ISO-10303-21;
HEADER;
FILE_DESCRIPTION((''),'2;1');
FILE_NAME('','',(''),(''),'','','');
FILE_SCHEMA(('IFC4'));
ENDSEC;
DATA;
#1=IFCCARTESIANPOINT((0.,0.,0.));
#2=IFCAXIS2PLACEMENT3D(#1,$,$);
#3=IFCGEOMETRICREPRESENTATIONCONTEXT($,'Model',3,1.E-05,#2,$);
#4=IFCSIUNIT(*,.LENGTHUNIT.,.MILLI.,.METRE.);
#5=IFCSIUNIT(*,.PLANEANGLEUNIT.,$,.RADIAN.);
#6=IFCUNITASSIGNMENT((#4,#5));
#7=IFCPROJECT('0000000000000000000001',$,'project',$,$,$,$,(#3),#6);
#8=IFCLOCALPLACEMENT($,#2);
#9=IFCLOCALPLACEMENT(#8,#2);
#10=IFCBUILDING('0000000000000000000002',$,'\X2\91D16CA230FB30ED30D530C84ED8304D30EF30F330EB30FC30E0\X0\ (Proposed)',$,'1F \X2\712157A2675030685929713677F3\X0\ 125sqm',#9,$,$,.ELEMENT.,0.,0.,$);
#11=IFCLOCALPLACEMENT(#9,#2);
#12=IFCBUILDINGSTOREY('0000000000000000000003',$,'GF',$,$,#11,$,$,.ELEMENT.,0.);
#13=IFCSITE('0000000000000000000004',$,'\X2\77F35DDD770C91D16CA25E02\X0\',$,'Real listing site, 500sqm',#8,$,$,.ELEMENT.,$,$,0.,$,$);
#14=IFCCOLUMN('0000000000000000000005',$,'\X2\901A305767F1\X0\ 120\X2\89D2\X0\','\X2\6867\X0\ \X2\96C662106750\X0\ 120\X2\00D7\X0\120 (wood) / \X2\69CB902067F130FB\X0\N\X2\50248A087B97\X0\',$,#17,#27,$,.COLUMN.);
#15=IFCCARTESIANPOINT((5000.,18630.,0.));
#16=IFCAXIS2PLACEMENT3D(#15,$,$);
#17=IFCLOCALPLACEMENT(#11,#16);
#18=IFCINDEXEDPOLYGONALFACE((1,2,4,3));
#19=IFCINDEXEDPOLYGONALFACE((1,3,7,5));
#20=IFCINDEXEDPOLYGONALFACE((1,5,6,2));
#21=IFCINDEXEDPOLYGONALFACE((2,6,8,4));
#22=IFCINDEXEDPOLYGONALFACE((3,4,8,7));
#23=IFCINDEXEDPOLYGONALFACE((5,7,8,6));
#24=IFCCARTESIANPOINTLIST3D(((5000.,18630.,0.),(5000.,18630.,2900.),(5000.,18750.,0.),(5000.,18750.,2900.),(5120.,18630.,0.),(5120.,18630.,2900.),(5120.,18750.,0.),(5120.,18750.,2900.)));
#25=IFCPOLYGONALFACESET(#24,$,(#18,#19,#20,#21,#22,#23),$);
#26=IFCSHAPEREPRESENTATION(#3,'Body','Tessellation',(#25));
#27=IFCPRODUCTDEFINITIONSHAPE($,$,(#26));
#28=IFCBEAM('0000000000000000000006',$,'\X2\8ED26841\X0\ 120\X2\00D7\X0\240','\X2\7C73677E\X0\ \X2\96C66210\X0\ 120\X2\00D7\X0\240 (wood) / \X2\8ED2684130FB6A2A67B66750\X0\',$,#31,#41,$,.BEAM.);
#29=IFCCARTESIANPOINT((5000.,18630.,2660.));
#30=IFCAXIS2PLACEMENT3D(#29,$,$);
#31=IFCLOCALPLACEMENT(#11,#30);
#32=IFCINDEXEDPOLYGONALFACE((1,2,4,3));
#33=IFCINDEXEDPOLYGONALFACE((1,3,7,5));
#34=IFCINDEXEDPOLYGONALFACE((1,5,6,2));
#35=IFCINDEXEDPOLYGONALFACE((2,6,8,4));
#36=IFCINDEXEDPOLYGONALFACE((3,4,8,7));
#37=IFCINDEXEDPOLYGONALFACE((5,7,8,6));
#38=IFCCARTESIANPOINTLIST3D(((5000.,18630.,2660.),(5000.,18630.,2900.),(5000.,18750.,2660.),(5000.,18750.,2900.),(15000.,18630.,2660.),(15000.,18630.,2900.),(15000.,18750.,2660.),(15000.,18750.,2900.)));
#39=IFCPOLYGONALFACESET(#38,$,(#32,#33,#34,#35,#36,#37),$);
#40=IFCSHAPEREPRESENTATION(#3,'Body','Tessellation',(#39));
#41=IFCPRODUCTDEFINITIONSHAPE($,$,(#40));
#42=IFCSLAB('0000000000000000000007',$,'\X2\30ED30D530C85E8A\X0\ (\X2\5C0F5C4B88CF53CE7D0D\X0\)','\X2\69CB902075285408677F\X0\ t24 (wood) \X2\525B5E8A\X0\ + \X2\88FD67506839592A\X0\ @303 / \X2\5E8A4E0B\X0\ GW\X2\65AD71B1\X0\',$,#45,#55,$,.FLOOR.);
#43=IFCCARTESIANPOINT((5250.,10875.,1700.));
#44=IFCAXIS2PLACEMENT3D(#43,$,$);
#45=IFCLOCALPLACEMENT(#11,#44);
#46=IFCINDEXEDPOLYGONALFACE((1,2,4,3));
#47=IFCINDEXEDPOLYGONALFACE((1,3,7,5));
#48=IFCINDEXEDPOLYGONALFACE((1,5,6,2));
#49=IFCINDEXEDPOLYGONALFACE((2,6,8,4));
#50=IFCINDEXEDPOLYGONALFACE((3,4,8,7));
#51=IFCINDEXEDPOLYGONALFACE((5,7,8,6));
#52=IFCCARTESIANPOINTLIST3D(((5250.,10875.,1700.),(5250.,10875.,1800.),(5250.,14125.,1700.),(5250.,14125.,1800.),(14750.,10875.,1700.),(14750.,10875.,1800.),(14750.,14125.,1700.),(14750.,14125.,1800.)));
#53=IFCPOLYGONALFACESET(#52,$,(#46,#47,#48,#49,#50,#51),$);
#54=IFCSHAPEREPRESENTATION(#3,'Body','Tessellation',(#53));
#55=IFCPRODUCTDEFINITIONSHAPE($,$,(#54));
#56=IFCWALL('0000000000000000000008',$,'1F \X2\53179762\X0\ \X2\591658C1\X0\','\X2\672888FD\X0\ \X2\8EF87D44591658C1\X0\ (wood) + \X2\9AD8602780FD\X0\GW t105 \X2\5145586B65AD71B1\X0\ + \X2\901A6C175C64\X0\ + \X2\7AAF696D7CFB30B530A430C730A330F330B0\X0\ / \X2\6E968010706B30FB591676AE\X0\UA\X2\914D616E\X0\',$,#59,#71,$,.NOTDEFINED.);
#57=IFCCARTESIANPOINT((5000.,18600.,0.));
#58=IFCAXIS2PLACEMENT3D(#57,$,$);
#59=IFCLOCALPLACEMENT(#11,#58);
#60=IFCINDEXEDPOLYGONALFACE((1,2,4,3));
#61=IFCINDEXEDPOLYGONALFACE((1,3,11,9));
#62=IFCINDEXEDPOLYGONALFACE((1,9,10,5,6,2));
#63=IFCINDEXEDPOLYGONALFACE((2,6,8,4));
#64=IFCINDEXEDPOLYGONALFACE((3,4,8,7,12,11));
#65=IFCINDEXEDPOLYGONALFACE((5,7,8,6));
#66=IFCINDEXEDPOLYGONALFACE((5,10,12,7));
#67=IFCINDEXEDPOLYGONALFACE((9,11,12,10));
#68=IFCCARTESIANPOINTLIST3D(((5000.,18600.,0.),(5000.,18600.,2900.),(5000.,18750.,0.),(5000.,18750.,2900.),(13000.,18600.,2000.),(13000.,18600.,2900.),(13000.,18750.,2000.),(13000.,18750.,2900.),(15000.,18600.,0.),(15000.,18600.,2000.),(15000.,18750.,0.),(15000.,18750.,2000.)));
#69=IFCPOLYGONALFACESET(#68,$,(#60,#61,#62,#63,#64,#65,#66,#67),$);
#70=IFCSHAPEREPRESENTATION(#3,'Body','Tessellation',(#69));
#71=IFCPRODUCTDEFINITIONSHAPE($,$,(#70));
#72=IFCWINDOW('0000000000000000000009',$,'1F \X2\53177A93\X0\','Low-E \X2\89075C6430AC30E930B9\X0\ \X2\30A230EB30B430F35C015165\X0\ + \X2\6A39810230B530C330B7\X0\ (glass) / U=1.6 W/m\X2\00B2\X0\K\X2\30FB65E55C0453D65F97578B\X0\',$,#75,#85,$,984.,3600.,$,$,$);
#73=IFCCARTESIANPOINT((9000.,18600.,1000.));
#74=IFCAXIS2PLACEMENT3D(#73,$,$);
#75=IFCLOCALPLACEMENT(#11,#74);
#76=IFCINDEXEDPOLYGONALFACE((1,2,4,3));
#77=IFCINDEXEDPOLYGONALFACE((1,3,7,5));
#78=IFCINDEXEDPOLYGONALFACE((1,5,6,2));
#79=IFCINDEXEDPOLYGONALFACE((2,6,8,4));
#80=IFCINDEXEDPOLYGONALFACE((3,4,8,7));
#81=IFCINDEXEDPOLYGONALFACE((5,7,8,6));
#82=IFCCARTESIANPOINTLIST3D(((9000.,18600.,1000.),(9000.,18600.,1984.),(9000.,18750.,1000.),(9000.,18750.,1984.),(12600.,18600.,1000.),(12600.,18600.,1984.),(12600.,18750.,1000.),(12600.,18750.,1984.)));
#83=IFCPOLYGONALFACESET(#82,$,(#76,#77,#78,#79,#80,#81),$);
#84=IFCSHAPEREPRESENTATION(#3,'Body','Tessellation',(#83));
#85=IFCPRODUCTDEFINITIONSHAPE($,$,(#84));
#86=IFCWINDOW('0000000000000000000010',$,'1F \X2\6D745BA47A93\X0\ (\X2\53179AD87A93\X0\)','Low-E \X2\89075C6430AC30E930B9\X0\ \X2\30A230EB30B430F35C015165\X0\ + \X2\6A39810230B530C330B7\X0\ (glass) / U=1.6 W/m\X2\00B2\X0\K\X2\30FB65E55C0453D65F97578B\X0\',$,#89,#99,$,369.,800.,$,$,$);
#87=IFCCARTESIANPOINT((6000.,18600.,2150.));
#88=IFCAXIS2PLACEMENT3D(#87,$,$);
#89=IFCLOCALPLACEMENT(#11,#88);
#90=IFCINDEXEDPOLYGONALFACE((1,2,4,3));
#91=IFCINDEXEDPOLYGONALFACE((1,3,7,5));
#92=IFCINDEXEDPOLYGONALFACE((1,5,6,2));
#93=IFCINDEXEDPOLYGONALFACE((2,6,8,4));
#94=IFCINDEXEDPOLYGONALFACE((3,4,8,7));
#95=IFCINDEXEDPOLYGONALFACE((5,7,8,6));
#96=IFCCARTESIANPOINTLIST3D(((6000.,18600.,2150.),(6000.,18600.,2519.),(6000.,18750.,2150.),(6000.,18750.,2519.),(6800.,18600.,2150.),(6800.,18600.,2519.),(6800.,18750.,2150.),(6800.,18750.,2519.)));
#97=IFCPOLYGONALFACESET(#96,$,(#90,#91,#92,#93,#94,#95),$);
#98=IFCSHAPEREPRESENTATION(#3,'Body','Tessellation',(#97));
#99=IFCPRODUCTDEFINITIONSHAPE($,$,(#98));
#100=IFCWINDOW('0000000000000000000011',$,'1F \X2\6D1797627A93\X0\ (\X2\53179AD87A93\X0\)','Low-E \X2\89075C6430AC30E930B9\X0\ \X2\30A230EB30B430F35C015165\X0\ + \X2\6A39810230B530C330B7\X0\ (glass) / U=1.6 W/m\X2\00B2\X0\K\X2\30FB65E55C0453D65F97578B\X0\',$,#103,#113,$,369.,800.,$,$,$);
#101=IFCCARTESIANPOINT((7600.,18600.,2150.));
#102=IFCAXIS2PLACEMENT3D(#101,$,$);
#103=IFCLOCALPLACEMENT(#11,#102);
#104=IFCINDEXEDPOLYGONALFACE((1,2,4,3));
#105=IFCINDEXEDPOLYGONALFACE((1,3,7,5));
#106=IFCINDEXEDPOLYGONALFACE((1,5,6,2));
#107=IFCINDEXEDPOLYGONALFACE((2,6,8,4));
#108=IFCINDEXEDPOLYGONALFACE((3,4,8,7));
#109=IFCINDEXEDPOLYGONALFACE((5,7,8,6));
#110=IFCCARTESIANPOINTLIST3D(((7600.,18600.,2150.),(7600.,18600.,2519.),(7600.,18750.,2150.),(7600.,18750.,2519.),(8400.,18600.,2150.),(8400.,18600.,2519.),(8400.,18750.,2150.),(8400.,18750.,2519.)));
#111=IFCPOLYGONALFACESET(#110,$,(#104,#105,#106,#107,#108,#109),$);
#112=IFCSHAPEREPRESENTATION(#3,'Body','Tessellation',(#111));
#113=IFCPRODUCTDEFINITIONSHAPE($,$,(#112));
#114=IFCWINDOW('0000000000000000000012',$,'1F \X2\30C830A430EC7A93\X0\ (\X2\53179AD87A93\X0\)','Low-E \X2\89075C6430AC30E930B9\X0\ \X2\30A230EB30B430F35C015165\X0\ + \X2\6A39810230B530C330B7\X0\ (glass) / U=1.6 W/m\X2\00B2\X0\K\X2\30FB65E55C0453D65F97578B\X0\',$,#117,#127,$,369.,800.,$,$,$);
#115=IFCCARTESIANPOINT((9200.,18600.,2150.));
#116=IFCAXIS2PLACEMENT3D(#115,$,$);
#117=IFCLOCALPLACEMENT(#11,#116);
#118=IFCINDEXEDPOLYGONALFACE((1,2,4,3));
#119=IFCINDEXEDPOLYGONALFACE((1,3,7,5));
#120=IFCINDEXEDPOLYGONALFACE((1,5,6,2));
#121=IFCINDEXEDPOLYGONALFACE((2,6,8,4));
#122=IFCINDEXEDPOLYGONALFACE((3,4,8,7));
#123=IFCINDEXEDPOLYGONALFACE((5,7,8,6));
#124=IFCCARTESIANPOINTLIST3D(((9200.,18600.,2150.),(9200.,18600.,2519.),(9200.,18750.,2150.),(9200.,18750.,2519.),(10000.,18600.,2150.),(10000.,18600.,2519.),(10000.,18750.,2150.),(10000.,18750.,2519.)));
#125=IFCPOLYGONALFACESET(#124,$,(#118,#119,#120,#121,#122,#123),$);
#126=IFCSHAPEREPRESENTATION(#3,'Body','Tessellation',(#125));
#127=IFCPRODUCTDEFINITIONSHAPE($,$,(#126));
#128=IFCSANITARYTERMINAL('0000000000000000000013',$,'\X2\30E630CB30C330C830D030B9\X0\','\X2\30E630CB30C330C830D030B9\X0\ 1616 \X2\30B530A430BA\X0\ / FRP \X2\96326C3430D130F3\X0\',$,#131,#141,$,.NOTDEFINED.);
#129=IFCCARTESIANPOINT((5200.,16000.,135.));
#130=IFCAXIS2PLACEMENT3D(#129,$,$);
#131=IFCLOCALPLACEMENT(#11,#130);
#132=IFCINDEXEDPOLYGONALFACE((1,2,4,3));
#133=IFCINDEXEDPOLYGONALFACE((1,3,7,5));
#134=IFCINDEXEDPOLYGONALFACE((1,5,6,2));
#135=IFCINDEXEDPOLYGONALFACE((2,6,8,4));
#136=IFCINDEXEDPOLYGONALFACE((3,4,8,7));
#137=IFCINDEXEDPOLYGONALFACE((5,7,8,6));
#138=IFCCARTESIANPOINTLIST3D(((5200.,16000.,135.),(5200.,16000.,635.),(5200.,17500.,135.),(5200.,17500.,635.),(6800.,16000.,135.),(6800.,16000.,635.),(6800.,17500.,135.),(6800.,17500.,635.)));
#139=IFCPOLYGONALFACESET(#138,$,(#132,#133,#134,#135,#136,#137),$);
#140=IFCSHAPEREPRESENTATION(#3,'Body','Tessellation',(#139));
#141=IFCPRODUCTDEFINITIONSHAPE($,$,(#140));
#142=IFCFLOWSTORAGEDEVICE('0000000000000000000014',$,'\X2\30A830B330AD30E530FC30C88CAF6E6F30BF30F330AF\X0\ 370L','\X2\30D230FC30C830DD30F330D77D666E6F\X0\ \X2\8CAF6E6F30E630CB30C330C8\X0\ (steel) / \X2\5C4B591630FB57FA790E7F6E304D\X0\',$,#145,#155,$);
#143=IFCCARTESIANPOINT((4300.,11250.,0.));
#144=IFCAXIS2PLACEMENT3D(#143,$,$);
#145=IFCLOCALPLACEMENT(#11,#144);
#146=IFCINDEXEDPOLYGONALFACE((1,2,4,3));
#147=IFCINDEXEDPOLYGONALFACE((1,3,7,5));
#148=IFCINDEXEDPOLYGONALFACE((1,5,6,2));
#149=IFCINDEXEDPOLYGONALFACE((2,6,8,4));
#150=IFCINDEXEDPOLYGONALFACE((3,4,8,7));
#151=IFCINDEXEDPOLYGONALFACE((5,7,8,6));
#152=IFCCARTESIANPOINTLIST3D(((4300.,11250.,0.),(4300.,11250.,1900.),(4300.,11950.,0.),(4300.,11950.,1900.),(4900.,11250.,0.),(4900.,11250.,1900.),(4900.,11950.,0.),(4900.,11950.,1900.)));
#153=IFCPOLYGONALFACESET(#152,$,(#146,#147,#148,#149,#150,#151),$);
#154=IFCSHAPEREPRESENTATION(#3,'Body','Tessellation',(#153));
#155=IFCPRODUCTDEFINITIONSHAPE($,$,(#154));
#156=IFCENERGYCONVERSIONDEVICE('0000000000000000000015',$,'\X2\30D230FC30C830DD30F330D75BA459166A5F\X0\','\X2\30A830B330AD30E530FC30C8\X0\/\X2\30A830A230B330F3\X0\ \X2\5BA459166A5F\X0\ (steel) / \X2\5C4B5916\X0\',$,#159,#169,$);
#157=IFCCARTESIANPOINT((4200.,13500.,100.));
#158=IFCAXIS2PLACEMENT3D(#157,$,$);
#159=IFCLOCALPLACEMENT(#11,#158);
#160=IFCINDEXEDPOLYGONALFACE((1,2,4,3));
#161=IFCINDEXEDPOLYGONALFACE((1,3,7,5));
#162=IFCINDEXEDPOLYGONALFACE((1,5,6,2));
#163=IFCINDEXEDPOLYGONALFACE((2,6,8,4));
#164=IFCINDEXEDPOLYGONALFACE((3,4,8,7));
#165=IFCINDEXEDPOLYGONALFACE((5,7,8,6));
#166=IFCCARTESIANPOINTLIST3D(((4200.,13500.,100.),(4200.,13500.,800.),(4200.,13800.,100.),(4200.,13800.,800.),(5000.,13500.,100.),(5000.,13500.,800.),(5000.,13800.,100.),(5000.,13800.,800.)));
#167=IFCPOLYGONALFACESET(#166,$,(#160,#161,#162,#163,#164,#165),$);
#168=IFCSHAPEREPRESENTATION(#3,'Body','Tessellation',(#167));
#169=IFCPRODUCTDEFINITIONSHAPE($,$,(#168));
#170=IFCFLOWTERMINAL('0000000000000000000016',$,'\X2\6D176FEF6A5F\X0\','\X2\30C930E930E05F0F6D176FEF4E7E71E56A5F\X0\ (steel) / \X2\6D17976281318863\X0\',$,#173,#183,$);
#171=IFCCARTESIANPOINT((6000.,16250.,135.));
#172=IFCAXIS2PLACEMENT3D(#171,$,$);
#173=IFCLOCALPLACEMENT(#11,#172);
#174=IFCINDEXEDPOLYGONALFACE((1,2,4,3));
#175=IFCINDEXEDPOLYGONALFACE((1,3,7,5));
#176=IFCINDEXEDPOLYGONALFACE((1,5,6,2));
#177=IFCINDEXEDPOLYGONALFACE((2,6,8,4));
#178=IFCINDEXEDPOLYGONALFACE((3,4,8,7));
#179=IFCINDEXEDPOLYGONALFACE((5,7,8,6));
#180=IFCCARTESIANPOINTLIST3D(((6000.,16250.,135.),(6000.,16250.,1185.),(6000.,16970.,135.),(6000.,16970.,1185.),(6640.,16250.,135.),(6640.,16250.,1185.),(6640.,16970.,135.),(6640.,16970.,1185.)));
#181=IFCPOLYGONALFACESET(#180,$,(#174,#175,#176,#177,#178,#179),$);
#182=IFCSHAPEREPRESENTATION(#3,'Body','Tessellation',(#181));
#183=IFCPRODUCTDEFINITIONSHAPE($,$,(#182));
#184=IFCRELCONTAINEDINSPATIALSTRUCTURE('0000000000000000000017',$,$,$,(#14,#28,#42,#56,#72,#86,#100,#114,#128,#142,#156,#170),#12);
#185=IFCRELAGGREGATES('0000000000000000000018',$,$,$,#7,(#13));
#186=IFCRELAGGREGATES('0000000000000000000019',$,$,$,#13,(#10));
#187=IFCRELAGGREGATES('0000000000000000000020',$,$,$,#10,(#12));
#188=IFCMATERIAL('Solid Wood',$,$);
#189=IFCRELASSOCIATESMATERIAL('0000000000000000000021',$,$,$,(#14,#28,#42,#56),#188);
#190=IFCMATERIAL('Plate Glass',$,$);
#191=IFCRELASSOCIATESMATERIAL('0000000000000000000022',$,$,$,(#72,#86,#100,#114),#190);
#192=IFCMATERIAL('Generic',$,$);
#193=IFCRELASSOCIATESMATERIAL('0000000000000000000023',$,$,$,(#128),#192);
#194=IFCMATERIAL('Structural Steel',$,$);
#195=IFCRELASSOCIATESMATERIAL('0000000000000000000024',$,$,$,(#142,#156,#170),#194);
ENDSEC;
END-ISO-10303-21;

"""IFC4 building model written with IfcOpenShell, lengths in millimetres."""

from ifc_helpers import new_model, si_unit, frame, frame_2d, origin, place, context, project, spatial, rectangle, extrude, material, element, fill, save


model = new_model("IFC4")

# Units and contexts
model_context = context("Model", 3, precision=1e-05, world=origin())
ifc_project = project(units=[si_unit("LENGTHUNIT", "METRE", prefix="MILLI"), si_unit("PLANEANGLEUNIT", "RADIAN")], contexts=[model_context])

# Site, building, storey
site_placement = place(None, origin())
site = spatial("IfcSite", under=ifc_project, at=site_placement, Name="石川県金沢市", ObjectType="Real listing site, 500sqm", CompositionType="ELEMENT", RefElevation=0.0)
building_placement = place(site_placement, origin())
building = spatial("IfcBuilding", under=site, at=building_placement, Name="金沢・ロフト付きワンルーム (Proposed)", ObjectType="1F 無垢材と天然石 125sqm", CompositionType="ELEMENT", ElevationOfRefHeight=0.0, ElevationOfTerrain=0.0)
storey_placement = place(building_placement, origin())
storey = spatial("IfcBuildingStorey", under=building, at=storey_placement, Name="GF", CompositionType="ELEMENT", Elevation=0.0)

# Column
ifc_material_1 = material(Name="Solid Wood")
column_1_placement = place(storey_placement, frame((5000.0, 18630.0, 0.0)))
element("IfcColumn", 1, at=column_1_placement, inside=storey, material=ifc_material_1, Name="通し柱 120角", Description="桧 集成材 120×120 (wood) / 構造柱・N値計算", PredefinedType="COLUMN", context=model_context, shape_type="SweptSolid", body=[
    extrude(rectangle(XDim=120.0, YDim=120.0, at=frame_2d((60.0, 60.0))), frame((5000.0, 18630.0, 0.0)), (0.0, 0.0, 1.0), 2900.0),
])

# Beam
beam_1_placement = place(storey_placement, frame((5000.0, 18630.0, 2660.0)))
element("IfcBeam", 2, at=beam_1_placement, inside=storey, material=ifc_material_1, Name="軒桁 120×240", Description="米松 集成 120×240 (wood) / 軒桁・横架材", PredefinedType="BEAM", context=model_context, shape_type="SweptSolid", body=[
    extrude(rectangle(XDim=10000.0, YDim=120.0, at=frame_2d((5000.0, 60.0))), frame((5000.0, 18630.0, 2660.0)), (0.0, 0.0, 1.0), 240.0),
])

# Slab
slab_placement = place(storey_placement, frame((5250.0, 10875.0, 1700.0)))
element("IfcSlab", 3, at=slab_placement, inside=storey, material=ifc_material_1, Name="ロフト床 (小屋裏収納)", Description="構造用合板 t24 (wood) 剛床 + 製材根太 @303 / 床下 GW断熱", PredefinedType="FLOOR", context=model_context, shape_type="SweptSolid", body=[
    extrude(rectangle(XDim=9500.0, YDim=3250.0, at=frame_2d((4750.0, 1625.0))), frame((5250.0, 10875.0, 1700.0)), (0.0, 0.0, 1.0), 100.0),
])

# Wall, openings, windows
wall_1_placement = place(storey_placement, frame((5000.0, 18600.0, 0.0)))
wall_1 = element("IfcWall", 4, at=wall_1_placement, inside=storey, material=ifc_material_1, Name="1F 北面 外壁", Description="木製 軸組外壁 (wood) + 高性能GW t105 充填断熱 + 通気層 + 窯業系サイディング / 準耐火・外皮UA配慮", PredefinedType="NOTDEFINED", context=model_context, shape_type="SweptSolid", body=[
    extrude(rectangle(XDim=10000.0, YDim=150.0, at=frame_2d((5000.0, 75.0))), frame((5000.0, 18600.0, 0.0)), (0.0, 0.0, 1.0), 2900.0),
])
opening_1_placement = place(storey_placement, frame((9000.0, 18600.0, 1000.0)))
opening_1 = element("IfcOpeningElement", 5, at=opening_1_placement, cuts=wall_1, PredefinedType="NOTDEFINED", context=model_context, shape_type="SweptSolid", body=[
    extrude(rectangle(XDim=3600.0, YDim=150.0, at=frame_2d((1800.0, 75.0))), frame((9000.0, 18600.0, 1000.0)), (0.0, 0.0, 1.0), 984.0),
])
opening_2_placement = place(storey_placement, frame((6000.0, 18600.0, 2150.0)))
opening_2 = element("IfcOpeningElement", 6, at=opening_2_placement, cuts=wall_1, PredefinedType="NOTDEFINED", context=model_context, shape_type="SweptSolid", body=[
    extrude(rectangle(XDim=800.0, YDim=150.0, at=frame_2d((400.0, 75.0))), frame((6000.0, 18600.0, 2150.0)), (0.0, 0.0, 1.0), 369.0),
])
opening_3_placement = place(storey_placement, frame((7600.0, 18600.0, 2150.0)))
opening_3 = element("IfcOpeningElement", 7, at=opening_3_placement, cuts=wall_1, PredefinedType="NOTDEFINED", context=model_context, shape_type="SweptSolid", body=[
    extrude(rectangle(XDim=800.0, YDim=150.0, at=frame_2d((400.0, 75.0))), frame((7600.0, 18600.0, 2150.0)), (0.0, 0.0, 1.0), 369.0),
])
opening_4_placement = place(storey_placement, frame((9200.0, 18600.0, 2150.0)))
opening_4 = element("IfcOpeningElement", 8, at=opening_4_placement, cuts=wall_1, PredefinedType="NOTDEFINED", context=model_context, shape_type="SweptSolid", body=[
    extrude(rectangle(XDim=800.0, YDim=150.0, at=frame_2d((400.0, 75.0))), frame((9200.0, 18600.0, 2150.0)), (0.0, 0.0, 1.0), 369.0),
])
ifc_material_2 = material(Name="Plate Glass")
window_1_placement = place(storey_placement, frame((9000.0, 18600.0, 1000.0)))
window_1 = element("IfcWindow", 9, at=window_1_placement, inside=storey, material=ifc_material_2, Name="1F 北窓", Description="Low-E 複層ガラス アルゴン封入 + 樹脂サッシ (glass) / U=1.6 W/m²K・日射取得型", OverallHeight=984.0, OverallWidth=3600.0, context=model_context, shape_type="SweptSolid", body=[
    extrude(rectangle(XDim=3600.0, YDim=150.0, at=frame_2d((1800.0, 75.0))), frame((9000.0, 18600.0, 1000.0)), (0.0, 0.0, 1.0), 984.0),
])
fill(opening_1, window_1)
window_2_placement = place(storey_placement, frame((6000.0, 18600.0, 2150.0)))
window_2 = element("IfcWindow", 10, at=window_2_placement, inside=storey, material=ifc_material_2, Name="1F 浴室窓 (北高窓)", Description="Low-E 複層ガラス アルゴン封入 + 樹脂サッシ (glass) / U=1.6 W/m²K・日射取得型", OverallHeight=369.0, OverallWidth=800.0, context=model_context, shape_type="SweptSolid", body=[
    extrude(rectangle(XDim=800.0, YDim=150.0, at=frame_2d((400.0, 75.0))), frame((6000.0, 18600.0, 2150.0)), (0.0, 0.0, 1.0), 369.0),
])
fill(opening_2, window_2)
window_3_placement = place(storey_placement, frame((7600.0, 18600.0, 2150.0)))
window_3 = element("IfcWindow", 11, at=window_3_placement, inside=storey, material=ifc_material_2, Name="1F 洗面窓 (北高窓)", Description="Low-E 複層ガラス アルゴン封入 + 樹脂サッシ (glass) / U=1.6 W/m²K・日射取得型", OverallHeight=369.0, OverallWidth=800.0, context=model_context, shape_type="SweptSolid", body=[
    extrude(rectangle(XDim=800.0, YDim=150.0, at=frame_2d((400.0, 75.0))), frame((7600.0, 18600.0, 2150.0)), (0.0, 0.0, 1.0), 369.0),
])
fill(opening_3, window_3)
window_4_placement = place(storey_placement, frame((9200.0, 18600.0, 2150.0)))
window_4 = element("IfcWindow", 12, at=window_4_placement, inside=storey, material=ifc_material_2, Name="1F トイレ窓 (北高窓)", Description="Low-E 複層ガラス アルゴン封入 + 樹脂サッシ (glass) / U=1.6 W/m²K・日射取得型", OverallHeight=369.0, OverallWidth=800.0, context=model_context, shape_type="SweptSolid", body=[
    extrude(rectangle(XDim=800.0, YDim=150.0, at=frame_2d((400.0, 75.0))), frame((9200.0, 18600.0, 2150.0)), (0.0, 0.0, 1.0), 369.0),
])
fill(opening_4, window_4)

# Sanitary terminal
ifc_material_3 = material(Name="Generic")
sanitary_terminal_placement = place(storey_placement, frame((5200.0, 16000.0, 135.0)))
element("IfcSanitaryTerminal", 13, at=sanitary_terminal_placement, inside=storey, material=ifc_material_3, Name="ユニットバス", Description="ユニットバス 1616 サイズ / FRP 防水パン", PredefinedType="NOTDEFINED", context=model_context, shape_type="SweptSolid", body=[
    extrude(rectangle(XDim=1600.0, YDim=1500.0, at=frame_2d((800.0, 750.0))), frame((5200.0, 16000.0, 135.0)), (0.0, 0.0, 1.0), 500.0),
])

# Flow storage device
ifc_material_4 = material(Name="Structural Steel")
flow_storage_device_placement = place(storey_placement, frame((4300.0, 11250.0, 0.0)))
element("IfcFlowStorageDevice", 14, at=flow_storage_device_placement, inside=storey, material=ifc_material_4, Name="エコキュート貯湯タンク 370L", Description="ヒートポンプ給湯 貯湯ユニット (steel) / 屋外・基礎置き", context=model_context, shape_type="SweptSolid", body=[
    extrude(rectangle(XDim=600.0, YDim=700.0, at=frame_2d((300.0, 350.0))), frame((4300.0, 11250.0, 0.0)), (0.0, 0.0, 1.0), 1900.0),
])

# Energy conversion device
energy_conversion_device_placement = place(storey_placement, frame((4200.0, 13500.0, 100.0)))
element("IfcEnergyConversionDevice", 15, at=energy_conversion_device_placement, inside=storey, material=ifc_material_4, Name="ヒートポンプ室外機", Description="エコキュート/エアコン 室外機 (steel) / 屋外", context=model_context, shape_type="SweptSolid", body=[
    extrude(rectangle(XDim=800.0, YDim=300.0, at=frame_2d((400.0, 150.0))), frame((4200.0, 13500.0, 100.0)), (0.0, 0.0, 1.0), 700.0),
])

# Flow terminal
flow_terminal_placement = place(storey_placement, frame((6000.0, 16250.0, 135.0)))
element("IfcFlowTerminal", 16, at=flow_terminal_placement, inside=storey, material=ifc_material_4, Name="洗濯機", Description="ドラム式洗濯乾燥機 (steel) / 洗面脱衣", context=model_context, shape_type="SweptSolid", body=[
    extrude(rectangle(XDim=640.0, YDim=720.0, at=frame_2d((320.0, 360.0))), frame((6000.0, 16250.0, 135.0)), (0.0, 0.0, 1.0), 1050.0),
])

save(model, "model.ifc")
